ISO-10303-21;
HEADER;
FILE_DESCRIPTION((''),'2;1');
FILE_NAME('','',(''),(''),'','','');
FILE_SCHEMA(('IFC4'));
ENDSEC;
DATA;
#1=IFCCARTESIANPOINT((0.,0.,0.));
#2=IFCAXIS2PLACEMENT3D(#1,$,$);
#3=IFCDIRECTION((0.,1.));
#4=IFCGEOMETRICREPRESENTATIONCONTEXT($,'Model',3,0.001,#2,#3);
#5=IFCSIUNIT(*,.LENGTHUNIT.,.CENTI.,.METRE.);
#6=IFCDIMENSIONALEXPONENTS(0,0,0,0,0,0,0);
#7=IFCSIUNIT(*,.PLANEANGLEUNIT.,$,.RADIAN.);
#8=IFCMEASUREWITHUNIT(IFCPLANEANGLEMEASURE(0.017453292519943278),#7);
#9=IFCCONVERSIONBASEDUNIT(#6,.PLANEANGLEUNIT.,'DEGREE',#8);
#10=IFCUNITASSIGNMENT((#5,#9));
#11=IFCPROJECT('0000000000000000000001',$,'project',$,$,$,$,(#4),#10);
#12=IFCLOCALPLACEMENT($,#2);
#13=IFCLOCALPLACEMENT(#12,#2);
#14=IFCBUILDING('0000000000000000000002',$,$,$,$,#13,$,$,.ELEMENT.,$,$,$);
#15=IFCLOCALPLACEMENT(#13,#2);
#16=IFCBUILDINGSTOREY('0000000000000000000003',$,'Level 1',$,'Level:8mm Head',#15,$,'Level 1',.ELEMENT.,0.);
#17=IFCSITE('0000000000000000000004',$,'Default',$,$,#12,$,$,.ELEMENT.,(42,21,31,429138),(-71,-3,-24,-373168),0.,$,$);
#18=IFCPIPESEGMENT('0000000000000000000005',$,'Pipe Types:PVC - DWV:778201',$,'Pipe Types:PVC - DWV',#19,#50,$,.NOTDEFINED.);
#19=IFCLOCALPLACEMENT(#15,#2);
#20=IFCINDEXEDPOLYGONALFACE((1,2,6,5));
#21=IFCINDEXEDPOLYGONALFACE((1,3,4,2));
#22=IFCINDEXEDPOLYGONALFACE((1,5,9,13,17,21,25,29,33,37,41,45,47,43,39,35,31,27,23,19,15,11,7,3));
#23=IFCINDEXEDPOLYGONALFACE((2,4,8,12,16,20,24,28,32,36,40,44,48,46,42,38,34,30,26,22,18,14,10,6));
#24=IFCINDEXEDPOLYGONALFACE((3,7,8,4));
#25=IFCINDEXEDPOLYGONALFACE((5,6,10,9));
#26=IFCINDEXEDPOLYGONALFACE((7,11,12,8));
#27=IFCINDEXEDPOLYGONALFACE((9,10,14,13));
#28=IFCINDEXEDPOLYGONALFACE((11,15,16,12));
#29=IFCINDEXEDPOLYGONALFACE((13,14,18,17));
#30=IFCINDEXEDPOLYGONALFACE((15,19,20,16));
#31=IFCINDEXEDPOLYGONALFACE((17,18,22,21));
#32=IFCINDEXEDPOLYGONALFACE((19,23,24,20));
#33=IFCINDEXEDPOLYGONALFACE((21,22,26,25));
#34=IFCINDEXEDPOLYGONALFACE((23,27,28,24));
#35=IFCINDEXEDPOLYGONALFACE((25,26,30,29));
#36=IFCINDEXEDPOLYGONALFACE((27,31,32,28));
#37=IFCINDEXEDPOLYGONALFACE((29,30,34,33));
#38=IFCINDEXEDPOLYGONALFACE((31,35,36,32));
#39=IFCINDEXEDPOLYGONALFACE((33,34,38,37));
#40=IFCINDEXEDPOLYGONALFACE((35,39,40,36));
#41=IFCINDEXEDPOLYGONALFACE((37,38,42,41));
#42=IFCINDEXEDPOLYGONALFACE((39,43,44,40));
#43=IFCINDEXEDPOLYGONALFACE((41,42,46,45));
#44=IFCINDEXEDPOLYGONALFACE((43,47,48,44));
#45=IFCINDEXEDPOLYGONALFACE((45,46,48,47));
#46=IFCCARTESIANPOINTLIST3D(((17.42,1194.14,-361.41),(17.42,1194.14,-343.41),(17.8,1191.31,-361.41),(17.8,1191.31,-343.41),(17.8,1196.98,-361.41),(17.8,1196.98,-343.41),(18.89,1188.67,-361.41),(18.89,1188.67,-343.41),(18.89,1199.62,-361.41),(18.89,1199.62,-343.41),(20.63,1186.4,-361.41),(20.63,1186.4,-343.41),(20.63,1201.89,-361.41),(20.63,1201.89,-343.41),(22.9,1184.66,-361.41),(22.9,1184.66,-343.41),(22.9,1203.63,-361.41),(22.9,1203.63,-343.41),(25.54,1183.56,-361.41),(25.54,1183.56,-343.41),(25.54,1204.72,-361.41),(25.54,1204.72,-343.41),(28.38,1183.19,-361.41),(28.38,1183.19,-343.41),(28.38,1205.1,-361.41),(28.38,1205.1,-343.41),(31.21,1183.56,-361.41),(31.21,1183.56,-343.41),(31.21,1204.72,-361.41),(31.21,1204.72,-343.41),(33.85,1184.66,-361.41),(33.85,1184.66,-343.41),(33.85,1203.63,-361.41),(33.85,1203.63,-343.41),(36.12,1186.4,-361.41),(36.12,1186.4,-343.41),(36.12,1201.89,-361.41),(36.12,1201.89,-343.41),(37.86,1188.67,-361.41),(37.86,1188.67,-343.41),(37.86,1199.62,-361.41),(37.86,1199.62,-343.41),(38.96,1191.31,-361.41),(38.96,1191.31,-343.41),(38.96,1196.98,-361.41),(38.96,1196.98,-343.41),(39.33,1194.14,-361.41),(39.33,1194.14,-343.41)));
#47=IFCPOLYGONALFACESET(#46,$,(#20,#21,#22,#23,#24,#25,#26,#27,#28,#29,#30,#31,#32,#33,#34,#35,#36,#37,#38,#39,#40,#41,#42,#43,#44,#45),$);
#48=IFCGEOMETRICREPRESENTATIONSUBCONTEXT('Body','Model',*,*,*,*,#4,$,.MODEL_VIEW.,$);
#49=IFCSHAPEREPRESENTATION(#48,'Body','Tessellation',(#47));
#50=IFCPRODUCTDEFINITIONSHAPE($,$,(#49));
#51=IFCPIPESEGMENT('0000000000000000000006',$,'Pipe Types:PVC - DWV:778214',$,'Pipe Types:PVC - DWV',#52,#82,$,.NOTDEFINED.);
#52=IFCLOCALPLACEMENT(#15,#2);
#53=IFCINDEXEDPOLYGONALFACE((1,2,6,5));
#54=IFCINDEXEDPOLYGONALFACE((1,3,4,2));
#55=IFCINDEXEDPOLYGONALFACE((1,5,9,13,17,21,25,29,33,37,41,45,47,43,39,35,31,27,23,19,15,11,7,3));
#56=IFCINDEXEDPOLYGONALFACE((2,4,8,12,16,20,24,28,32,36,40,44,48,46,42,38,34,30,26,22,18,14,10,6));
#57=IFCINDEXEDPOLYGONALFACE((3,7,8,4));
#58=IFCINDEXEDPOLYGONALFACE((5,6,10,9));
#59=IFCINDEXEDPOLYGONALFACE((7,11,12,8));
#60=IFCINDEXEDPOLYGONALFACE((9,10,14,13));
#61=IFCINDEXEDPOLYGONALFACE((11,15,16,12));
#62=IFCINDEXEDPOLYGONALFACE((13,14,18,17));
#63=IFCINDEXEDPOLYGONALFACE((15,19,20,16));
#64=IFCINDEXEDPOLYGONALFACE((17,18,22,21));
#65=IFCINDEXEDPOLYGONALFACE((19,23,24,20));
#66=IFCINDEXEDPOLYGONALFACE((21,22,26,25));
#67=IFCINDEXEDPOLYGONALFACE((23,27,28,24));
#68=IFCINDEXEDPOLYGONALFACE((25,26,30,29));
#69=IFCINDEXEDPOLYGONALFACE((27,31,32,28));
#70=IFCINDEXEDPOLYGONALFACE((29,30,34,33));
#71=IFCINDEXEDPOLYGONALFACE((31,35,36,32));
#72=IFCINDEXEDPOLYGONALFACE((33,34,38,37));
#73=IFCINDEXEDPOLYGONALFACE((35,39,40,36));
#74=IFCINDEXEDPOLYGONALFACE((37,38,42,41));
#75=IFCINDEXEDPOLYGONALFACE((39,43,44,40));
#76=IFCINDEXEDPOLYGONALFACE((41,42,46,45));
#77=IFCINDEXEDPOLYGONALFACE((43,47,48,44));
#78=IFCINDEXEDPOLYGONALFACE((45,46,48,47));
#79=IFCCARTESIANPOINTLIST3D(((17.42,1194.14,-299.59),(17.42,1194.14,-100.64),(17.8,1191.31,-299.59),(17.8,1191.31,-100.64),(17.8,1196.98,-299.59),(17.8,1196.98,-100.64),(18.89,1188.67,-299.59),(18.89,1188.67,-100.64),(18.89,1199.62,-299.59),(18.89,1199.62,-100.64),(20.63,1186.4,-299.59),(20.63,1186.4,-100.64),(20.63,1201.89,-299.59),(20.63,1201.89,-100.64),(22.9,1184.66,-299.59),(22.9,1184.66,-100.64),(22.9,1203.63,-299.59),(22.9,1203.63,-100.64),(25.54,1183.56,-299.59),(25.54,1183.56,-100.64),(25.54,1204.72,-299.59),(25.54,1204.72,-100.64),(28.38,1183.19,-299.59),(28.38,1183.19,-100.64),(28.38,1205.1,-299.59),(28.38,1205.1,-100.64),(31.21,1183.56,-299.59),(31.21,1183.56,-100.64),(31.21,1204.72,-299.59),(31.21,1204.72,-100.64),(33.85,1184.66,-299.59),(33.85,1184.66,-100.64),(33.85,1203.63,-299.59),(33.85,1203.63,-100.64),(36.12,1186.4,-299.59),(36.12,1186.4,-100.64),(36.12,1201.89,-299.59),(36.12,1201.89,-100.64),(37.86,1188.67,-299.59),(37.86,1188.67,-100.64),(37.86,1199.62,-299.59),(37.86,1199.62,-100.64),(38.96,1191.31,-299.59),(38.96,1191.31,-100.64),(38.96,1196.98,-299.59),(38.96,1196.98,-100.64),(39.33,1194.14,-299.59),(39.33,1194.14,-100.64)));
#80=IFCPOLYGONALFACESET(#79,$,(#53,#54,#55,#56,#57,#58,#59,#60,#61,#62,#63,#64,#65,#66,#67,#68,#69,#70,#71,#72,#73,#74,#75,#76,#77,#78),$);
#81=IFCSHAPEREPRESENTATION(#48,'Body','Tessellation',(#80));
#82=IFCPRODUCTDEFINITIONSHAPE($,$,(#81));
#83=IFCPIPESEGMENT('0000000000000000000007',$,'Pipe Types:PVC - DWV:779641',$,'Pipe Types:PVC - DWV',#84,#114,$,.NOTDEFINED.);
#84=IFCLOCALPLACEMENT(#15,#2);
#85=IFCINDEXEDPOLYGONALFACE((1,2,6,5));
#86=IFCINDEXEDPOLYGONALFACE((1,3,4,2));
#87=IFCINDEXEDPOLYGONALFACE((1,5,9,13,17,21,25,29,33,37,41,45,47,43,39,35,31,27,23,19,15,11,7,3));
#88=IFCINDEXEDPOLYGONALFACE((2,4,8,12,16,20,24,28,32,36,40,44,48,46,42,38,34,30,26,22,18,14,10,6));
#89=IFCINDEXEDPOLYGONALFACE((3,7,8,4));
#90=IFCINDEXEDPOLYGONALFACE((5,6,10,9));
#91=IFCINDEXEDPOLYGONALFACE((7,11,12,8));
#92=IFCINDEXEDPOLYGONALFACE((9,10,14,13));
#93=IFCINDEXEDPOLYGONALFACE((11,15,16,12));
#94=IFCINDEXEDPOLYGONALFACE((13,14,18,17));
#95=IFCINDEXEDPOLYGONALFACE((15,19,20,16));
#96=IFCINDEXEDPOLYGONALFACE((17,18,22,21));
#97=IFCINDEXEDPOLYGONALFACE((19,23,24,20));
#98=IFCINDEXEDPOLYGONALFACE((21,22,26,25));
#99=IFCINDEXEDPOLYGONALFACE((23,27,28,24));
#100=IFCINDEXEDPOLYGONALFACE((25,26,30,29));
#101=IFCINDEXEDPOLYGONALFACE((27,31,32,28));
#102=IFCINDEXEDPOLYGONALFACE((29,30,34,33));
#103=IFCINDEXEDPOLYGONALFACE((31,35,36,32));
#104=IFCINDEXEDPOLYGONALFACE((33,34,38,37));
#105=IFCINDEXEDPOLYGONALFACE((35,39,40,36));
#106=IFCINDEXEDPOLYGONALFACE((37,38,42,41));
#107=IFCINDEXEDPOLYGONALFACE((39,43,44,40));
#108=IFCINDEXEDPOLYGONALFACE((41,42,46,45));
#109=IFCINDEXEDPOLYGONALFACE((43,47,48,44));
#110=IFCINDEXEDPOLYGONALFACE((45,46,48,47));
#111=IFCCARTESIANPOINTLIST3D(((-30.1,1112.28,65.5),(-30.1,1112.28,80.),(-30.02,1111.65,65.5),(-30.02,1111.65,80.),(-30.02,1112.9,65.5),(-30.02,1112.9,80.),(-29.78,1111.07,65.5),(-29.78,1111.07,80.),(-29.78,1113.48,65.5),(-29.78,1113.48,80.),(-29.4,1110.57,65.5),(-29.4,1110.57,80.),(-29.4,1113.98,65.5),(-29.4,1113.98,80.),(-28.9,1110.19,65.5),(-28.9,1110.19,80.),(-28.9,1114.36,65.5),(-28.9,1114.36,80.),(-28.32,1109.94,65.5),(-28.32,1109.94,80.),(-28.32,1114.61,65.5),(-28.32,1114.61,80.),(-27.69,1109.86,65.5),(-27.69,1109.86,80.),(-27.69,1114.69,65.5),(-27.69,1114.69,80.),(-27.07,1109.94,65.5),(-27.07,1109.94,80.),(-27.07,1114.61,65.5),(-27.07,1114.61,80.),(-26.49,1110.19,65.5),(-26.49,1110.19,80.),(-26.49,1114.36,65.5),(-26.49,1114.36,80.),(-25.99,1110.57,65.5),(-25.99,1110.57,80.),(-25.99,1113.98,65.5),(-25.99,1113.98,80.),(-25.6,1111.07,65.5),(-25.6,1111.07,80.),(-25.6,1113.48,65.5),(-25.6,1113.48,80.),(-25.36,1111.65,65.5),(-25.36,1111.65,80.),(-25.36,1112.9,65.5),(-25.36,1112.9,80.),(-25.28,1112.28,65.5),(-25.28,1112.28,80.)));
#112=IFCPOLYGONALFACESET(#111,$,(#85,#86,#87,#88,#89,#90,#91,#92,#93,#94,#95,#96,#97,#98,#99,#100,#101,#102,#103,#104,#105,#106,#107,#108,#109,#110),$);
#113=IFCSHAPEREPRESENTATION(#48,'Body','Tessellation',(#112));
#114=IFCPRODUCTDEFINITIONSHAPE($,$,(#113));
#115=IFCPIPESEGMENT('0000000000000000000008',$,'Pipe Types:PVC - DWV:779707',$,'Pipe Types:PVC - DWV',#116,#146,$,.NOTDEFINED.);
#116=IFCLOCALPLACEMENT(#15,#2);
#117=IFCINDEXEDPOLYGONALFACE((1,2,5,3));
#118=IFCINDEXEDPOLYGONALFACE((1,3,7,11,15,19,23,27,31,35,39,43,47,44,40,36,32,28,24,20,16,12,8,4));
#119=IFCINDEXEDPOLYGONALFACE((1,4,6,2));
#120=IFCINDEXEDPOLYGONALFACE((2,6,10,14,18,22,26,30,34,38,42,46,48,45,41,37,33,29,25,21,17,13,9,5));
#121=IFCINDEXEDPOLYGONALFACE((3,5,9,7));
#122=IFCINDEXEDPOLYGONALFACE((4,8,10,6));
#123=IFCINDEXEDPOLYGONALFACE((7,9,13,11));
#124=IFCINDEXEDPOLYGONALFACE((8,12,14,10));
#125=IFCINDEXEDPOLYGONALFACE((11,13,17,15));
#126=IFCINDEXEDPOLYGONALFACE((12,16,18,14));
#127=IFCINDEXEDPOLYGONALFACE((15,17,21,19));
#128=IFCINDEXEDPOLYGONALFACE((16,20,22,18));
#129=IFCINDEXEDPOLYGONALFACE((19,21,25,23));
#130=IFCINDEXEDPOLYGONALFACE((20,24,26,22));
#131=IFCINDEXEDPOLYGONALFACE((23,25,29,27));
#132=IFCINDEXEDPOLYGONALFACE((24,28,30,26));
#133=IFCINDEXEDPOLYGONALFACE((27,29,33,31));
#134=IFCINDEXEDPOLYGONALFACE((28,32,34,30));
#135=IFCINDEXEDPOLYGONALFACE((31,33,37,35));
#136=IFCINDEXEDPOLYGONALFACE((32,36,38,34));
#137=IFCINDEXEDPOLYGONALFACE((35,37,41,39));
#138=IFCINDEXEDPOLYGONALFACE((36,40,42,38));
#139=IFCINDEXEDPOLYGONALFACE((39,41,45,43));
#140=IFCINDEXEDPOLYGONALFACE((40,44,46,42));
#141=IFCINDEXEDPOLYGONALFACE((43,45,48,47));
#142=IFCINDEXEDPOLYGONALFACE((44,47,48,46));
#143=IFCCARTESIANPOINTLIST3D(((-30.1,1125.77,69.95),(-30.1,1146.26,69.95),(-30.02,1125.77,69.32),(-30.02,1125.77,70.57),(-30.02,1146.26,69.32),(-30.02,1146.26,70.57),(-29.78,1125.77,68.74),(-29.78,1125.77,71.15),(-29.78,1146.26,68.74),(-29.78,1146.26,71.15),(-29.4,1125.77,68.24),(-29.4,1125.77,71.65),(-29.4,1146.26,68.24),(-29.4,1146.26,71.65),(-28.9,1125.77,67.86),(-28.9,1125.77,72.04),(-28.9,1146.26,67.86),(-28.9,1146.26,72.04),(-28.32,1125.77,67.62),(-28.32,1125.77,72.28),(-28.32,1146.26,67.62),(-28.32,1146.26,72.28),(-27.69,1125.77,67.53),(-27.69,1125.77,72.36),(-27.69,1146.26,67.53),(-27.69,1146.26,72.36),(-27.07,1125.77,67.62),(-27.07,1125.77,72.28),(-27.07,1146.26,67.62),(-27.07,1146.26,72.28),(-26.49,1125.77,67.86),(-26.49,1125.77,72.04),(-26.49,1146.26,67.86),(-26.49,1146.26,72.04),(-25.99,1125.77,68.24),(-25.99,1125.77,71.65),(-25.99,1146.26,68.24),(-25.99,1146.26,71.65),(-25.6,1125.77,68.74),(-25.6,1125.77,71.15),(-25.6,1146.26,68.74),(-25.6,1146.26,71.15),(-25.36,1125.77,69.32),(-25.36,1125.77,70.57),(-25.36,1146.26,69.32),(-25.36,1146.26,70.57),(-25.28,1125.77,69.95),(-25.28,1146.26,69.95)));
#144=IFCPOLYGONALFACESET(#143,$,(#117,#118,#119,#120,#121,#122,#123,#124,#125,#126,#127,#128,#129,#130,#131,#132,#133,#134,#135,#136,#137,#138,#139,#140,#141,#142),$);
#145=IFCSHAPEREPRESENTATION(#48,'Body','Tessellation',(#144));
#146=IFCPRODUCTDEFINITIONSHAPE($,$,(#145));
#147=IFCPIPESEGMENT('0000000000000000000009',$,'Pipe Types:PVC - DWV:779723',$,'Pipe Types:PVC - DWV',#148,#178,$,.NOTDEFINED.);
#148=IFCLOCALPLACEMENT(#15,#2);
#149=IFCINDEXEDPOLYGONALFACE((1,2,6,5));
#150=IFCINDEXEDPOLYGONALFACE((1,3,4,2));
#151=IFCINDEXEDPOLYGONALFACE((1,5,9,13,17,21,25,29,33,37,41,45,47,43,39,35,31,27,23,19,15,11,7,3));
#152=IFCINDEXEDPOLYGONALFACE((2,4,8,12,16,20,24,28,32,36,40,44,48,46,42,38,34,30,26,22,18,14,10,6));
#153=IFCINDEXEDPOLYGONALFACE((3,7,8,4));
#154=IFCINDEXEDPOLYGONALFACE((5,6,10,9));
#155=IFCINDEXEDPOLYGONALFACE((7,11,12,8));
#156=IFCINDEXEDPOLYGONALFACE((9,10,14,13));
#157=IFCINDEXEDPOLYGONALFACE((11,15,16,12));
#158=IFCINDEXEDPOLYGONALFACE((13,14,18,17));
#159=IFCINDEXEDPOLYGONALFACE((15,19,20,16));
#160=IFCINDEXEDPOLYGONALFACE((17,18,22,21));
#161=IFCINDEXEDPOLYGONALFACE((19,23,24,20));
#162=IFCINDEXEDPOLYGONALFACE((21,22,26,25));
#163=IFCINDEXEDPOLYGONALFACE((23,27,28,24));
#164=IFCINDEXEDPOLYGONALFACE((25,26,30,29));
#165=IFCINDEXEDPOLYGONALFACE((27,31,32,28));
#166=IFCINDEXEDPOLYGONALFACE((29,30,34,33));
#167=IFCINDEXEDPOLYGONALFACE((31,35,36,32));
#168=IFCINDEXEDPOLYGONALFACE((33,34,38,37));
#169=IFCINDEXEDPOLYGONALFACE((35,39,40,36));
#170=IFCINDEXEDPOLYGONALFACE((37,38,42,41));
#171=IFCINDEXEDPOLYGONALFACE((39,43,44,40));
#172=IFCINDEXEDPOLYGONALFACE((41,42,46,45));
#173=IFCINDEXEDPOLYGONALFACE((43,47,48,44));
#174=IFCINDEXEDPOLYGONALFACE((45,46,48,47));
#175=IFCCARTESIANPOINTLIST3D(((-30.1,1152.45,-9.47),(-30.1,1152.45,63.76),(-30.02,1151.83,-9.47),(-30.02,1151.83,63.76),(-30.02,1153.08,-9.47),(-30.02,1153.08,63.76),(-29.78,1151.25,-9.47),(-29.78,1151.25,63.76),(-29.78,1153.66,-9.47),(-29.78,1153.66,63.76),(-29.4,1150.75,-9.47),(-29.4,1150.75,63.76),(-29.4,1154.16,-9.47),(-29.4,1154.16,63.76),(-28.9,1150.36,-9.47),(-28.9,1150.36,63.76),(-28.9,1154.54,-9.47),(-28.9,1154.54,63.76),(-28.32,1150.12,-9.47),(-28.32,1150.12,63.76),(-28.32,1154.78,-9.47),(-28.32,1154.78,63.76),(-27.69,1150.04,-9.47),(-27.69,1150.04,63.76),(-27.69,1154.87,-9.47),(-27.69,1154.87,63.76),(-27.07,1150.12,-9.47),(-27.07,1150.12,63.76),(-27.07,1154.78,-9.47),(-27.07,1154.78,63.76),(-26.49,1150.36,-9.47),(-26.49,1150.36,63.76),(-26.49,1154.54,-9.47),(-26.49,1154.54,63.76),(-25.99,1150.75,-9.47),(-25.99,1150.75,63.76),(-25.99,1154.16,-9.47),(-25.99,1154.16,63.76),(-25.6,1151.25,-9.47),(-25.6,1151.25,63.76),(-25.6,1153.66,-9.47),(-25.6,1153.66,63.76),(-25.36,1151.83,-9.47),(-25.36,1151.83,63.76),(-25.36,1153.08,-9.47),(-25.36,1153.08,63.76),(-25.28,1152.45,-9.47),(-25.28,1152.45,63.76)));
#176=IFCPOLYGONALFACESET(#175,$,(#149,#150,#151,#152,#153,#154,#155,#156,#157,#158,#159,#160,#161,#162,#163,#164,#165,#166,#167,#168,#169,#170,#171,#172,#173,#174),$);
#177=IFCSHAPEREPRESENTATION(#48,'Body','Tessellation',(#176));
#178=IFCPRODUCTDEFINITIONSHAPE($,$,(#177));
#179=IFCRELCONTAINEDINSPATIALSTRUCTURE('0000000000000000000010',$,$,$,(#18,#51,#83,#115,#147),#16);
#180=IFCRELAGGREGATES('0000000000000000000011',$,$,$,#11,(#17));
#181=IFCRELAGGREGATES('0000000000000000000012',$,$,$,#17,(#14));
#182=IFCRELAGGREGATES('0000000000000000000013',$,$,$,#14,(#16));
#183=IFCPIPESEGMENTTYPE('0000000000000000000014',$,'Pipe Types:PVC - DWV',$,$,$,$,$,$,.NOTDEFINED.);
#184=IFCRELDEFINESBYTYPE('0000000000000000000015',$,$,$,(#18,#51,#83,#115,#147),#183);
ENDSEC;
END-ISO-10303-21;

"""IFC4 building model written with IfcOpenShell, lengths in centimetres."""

from ifc_helpers import new_model, entity, si_unit, converted_unit, direction, frame, origin, place, context, subcontext, project, spatial, arc, indexed_curve, outline, extrude, type_object, element, save


model = new_model("IFC4")

# Units and contexts
model_context = context("Model", 3, precision=0.001, world=origin(), true_north=direction((0.0, 1.0)))
body_context = subcontext(model_context, "Body", "Model", "MODEL_VIEW")
ifc_project = project(units=[si_unit("LENGTHUNIT", "METRE", prefix="CENTI"), converted_unit("PLANEANGLEUNIT", "DEGREE", entity("IfcPlaneAngleMeasure", 0.017453292519943278), si_unit("PLANEANGLEUNIT", "RADIAN"), dimensions=[0, 0, 0, 0, 0, 0, 0])], contexts=[model_context])

# Site, building, storey
site_placement = place(None, origin())
site = spatial("IfcSite", under=ifc_project, at=site_placement, Name="Default", CompositionType="ELEMENT", RefLatitude=(42, 21, 31, 429138), RefLongitude=(-71, -3, -24, -373168), RefElevation=0.0)
building_placement = place(site_placement, origin())
building = spatial("IfcBuilding", under=site, at=building_placement, CompositionType="ELEMENT")
storey_placement = place(building_placement, origin())
storey = spatial("IfcBuildingStorey", under=building, at=storey_placement, Name="Level 1", ObjectType="Level:8mm Head", LongName="Level 1", CompositionType="ELEMENT", Elevation=0.0)

# Pipe segments
pipe_segment_type = type_object("IfcPipeSegmentType", Name="Pipe Types:PVC - DWV", PredefinedType="NOTDEFINED")
pipe_segment_1_placement = place(storey_placement, origin())
element("IfcPipeSegment", 1, at=pipe_segment_1_placement, inside=storey, type_object=pipe_segment_type, Name="Pipe Types:PVC - DWV:778201", ObjectType="Pipe Types:PVC - DWV", PredefinedType="NOTDEFINED", context=body_context, shape_type="SweptSolid", body=[
    extrude(outline(indexed_curve([(10.95, 0.0), (7.75, 7.75), (0.0, 10.95), (-7.75, 7.75), (-10.95, 0.0), (-7.75, -7.75), (0.0, -10.95), (7.75, -7.75)], segments=[arc(1, 2, 3), arc(3, 4, 5), arc(5, 6, 7), arc(7, 8, 1)], self_intersect=False)), frame((28.38, 1194.14, -361.41)), (0.0, 0.0, 1.0), 18.0),
])
pipe_segment_2_placement = place(storey_placement, origin())
element("IfcPipeSegment", 2, at=pipe_segment_2_placement, inside=storey, type_object=pipe_segment_type, Name="Pipe Types:PVC - DWV:778214", ObjectType="Pipe Types:PVC - DWV", PredefinedType="NOTDEFINED", context=body_context, shape_type="SweptSolid", body=[
    extrude(outline(indexed_curve([(10.95, 0.0), (7.75, 7.75), (0.0, 10.95), (-7.75, 7.75), (-10.95, 0.0), (-7.75, -7.75), (0.0, -10.95), (7.75, -7.75)], segments=[arc(1, 2, 3), arc(3, 4, 5), arc(5, 6, 7), arc(7, 8, 1)], self_intersect=False)), frame((28.38, 1194.14, -299.59)), (0.0, 0.0, 1.0), 198.95),
])
pipe_segment_3_placement = place(storey_placement, origin())
element("IfcPipeSegment", 3, at=pipe_segment_3_placement, inside=storey, type_object=pipe_segment_type, Name="Pipe Types:PVC - DWV:779641", ObjectType="Pipe Types:PVC - DWV", PredefinedType="NOTDEFINED", context=body_context, shape_type="SweptSolid", body=[
    extrude(outline(indexed_curve([(2.41, 0.0), (1.71, 1.71), (0.0, 2.41), (-1.71, 1.71), (-2.41, 0.0), (-1.71, -1.71), (0.0, -2.41), (1.71, -1.71)], segments=[arc(1, 2, 3), arc(3, 4, 5), arc(5, 6, 7), arc(7, 8, 1)], self_intersect=False)), frame((-27.69, 1112.28, 65.5)), (0.0, 0.0, 1.0), 14.5),
])
pipe_segment_4_placement = place(storey_placement, origin())
element("IfcPipeSegment", 4, at=pipe_segment_4_placement, inside=storey, type_object=pipe_segment_type, Name="Pipe Types:PVC - DWV:779707", ObjectType="Pipe Types:PVC - DWV", PredefinedType="NOTDEFINED", context=body_context, shape_type="SweptSolid", body=[
    extrude(outline(indexed_curve([(2.41, 0.0), (1.71, 1.71), (0.0, 2.41), (-1.71, 1.71), (-2.41, 0.0), (-1.71, -1.71), (0.0, -2.41), (1.71, -1.71)], segments=[arc(1, 2, 3), arc(3, 4, 5), arc(5, 6, 7), arc(7, 8, 1)], self_intersect=False)), frame((-27.69, 1125.77, 69.95), z_axis=(0.0, 1.0, 0.0), x_axis=(1.0, 0.0, 0.0)), (0.0, 0.0, 1.0), 20.5),
])
pipe_segment_5_placement = place(storey_placement, origin())
element("IfcPipeSegment", 5, at=pipe_segment_5_placement, inside=storey, type_object=pipe_segment_type, Name="Pipe Types:PVC - DWV:779723", ObjectType="Pipe Types:PVC - DWV", PredefinedType="NOTDEFINED", context=body_context, shape_type="SweptSolid", body=[
    extrude(outline(indexed_curve([(2.41, 0.0), (1.71, 1.71), (0.0, 2.41), (-1.71, 1.71), (-2.41, 0.0), (-1.71, -1.71), (0.0, -2.41), (1.71, -1.71)], segments=[arc(1, 2, 3), arc(3, 4, 5), arc(5, 6, 7), arc(7, 8, 1)], self_intersect=False)), frame((-27.69, 1152.45, -9.47)), (0.0, 0.0, 1.0), 73.23),
])

save(model, "model.ifc")
